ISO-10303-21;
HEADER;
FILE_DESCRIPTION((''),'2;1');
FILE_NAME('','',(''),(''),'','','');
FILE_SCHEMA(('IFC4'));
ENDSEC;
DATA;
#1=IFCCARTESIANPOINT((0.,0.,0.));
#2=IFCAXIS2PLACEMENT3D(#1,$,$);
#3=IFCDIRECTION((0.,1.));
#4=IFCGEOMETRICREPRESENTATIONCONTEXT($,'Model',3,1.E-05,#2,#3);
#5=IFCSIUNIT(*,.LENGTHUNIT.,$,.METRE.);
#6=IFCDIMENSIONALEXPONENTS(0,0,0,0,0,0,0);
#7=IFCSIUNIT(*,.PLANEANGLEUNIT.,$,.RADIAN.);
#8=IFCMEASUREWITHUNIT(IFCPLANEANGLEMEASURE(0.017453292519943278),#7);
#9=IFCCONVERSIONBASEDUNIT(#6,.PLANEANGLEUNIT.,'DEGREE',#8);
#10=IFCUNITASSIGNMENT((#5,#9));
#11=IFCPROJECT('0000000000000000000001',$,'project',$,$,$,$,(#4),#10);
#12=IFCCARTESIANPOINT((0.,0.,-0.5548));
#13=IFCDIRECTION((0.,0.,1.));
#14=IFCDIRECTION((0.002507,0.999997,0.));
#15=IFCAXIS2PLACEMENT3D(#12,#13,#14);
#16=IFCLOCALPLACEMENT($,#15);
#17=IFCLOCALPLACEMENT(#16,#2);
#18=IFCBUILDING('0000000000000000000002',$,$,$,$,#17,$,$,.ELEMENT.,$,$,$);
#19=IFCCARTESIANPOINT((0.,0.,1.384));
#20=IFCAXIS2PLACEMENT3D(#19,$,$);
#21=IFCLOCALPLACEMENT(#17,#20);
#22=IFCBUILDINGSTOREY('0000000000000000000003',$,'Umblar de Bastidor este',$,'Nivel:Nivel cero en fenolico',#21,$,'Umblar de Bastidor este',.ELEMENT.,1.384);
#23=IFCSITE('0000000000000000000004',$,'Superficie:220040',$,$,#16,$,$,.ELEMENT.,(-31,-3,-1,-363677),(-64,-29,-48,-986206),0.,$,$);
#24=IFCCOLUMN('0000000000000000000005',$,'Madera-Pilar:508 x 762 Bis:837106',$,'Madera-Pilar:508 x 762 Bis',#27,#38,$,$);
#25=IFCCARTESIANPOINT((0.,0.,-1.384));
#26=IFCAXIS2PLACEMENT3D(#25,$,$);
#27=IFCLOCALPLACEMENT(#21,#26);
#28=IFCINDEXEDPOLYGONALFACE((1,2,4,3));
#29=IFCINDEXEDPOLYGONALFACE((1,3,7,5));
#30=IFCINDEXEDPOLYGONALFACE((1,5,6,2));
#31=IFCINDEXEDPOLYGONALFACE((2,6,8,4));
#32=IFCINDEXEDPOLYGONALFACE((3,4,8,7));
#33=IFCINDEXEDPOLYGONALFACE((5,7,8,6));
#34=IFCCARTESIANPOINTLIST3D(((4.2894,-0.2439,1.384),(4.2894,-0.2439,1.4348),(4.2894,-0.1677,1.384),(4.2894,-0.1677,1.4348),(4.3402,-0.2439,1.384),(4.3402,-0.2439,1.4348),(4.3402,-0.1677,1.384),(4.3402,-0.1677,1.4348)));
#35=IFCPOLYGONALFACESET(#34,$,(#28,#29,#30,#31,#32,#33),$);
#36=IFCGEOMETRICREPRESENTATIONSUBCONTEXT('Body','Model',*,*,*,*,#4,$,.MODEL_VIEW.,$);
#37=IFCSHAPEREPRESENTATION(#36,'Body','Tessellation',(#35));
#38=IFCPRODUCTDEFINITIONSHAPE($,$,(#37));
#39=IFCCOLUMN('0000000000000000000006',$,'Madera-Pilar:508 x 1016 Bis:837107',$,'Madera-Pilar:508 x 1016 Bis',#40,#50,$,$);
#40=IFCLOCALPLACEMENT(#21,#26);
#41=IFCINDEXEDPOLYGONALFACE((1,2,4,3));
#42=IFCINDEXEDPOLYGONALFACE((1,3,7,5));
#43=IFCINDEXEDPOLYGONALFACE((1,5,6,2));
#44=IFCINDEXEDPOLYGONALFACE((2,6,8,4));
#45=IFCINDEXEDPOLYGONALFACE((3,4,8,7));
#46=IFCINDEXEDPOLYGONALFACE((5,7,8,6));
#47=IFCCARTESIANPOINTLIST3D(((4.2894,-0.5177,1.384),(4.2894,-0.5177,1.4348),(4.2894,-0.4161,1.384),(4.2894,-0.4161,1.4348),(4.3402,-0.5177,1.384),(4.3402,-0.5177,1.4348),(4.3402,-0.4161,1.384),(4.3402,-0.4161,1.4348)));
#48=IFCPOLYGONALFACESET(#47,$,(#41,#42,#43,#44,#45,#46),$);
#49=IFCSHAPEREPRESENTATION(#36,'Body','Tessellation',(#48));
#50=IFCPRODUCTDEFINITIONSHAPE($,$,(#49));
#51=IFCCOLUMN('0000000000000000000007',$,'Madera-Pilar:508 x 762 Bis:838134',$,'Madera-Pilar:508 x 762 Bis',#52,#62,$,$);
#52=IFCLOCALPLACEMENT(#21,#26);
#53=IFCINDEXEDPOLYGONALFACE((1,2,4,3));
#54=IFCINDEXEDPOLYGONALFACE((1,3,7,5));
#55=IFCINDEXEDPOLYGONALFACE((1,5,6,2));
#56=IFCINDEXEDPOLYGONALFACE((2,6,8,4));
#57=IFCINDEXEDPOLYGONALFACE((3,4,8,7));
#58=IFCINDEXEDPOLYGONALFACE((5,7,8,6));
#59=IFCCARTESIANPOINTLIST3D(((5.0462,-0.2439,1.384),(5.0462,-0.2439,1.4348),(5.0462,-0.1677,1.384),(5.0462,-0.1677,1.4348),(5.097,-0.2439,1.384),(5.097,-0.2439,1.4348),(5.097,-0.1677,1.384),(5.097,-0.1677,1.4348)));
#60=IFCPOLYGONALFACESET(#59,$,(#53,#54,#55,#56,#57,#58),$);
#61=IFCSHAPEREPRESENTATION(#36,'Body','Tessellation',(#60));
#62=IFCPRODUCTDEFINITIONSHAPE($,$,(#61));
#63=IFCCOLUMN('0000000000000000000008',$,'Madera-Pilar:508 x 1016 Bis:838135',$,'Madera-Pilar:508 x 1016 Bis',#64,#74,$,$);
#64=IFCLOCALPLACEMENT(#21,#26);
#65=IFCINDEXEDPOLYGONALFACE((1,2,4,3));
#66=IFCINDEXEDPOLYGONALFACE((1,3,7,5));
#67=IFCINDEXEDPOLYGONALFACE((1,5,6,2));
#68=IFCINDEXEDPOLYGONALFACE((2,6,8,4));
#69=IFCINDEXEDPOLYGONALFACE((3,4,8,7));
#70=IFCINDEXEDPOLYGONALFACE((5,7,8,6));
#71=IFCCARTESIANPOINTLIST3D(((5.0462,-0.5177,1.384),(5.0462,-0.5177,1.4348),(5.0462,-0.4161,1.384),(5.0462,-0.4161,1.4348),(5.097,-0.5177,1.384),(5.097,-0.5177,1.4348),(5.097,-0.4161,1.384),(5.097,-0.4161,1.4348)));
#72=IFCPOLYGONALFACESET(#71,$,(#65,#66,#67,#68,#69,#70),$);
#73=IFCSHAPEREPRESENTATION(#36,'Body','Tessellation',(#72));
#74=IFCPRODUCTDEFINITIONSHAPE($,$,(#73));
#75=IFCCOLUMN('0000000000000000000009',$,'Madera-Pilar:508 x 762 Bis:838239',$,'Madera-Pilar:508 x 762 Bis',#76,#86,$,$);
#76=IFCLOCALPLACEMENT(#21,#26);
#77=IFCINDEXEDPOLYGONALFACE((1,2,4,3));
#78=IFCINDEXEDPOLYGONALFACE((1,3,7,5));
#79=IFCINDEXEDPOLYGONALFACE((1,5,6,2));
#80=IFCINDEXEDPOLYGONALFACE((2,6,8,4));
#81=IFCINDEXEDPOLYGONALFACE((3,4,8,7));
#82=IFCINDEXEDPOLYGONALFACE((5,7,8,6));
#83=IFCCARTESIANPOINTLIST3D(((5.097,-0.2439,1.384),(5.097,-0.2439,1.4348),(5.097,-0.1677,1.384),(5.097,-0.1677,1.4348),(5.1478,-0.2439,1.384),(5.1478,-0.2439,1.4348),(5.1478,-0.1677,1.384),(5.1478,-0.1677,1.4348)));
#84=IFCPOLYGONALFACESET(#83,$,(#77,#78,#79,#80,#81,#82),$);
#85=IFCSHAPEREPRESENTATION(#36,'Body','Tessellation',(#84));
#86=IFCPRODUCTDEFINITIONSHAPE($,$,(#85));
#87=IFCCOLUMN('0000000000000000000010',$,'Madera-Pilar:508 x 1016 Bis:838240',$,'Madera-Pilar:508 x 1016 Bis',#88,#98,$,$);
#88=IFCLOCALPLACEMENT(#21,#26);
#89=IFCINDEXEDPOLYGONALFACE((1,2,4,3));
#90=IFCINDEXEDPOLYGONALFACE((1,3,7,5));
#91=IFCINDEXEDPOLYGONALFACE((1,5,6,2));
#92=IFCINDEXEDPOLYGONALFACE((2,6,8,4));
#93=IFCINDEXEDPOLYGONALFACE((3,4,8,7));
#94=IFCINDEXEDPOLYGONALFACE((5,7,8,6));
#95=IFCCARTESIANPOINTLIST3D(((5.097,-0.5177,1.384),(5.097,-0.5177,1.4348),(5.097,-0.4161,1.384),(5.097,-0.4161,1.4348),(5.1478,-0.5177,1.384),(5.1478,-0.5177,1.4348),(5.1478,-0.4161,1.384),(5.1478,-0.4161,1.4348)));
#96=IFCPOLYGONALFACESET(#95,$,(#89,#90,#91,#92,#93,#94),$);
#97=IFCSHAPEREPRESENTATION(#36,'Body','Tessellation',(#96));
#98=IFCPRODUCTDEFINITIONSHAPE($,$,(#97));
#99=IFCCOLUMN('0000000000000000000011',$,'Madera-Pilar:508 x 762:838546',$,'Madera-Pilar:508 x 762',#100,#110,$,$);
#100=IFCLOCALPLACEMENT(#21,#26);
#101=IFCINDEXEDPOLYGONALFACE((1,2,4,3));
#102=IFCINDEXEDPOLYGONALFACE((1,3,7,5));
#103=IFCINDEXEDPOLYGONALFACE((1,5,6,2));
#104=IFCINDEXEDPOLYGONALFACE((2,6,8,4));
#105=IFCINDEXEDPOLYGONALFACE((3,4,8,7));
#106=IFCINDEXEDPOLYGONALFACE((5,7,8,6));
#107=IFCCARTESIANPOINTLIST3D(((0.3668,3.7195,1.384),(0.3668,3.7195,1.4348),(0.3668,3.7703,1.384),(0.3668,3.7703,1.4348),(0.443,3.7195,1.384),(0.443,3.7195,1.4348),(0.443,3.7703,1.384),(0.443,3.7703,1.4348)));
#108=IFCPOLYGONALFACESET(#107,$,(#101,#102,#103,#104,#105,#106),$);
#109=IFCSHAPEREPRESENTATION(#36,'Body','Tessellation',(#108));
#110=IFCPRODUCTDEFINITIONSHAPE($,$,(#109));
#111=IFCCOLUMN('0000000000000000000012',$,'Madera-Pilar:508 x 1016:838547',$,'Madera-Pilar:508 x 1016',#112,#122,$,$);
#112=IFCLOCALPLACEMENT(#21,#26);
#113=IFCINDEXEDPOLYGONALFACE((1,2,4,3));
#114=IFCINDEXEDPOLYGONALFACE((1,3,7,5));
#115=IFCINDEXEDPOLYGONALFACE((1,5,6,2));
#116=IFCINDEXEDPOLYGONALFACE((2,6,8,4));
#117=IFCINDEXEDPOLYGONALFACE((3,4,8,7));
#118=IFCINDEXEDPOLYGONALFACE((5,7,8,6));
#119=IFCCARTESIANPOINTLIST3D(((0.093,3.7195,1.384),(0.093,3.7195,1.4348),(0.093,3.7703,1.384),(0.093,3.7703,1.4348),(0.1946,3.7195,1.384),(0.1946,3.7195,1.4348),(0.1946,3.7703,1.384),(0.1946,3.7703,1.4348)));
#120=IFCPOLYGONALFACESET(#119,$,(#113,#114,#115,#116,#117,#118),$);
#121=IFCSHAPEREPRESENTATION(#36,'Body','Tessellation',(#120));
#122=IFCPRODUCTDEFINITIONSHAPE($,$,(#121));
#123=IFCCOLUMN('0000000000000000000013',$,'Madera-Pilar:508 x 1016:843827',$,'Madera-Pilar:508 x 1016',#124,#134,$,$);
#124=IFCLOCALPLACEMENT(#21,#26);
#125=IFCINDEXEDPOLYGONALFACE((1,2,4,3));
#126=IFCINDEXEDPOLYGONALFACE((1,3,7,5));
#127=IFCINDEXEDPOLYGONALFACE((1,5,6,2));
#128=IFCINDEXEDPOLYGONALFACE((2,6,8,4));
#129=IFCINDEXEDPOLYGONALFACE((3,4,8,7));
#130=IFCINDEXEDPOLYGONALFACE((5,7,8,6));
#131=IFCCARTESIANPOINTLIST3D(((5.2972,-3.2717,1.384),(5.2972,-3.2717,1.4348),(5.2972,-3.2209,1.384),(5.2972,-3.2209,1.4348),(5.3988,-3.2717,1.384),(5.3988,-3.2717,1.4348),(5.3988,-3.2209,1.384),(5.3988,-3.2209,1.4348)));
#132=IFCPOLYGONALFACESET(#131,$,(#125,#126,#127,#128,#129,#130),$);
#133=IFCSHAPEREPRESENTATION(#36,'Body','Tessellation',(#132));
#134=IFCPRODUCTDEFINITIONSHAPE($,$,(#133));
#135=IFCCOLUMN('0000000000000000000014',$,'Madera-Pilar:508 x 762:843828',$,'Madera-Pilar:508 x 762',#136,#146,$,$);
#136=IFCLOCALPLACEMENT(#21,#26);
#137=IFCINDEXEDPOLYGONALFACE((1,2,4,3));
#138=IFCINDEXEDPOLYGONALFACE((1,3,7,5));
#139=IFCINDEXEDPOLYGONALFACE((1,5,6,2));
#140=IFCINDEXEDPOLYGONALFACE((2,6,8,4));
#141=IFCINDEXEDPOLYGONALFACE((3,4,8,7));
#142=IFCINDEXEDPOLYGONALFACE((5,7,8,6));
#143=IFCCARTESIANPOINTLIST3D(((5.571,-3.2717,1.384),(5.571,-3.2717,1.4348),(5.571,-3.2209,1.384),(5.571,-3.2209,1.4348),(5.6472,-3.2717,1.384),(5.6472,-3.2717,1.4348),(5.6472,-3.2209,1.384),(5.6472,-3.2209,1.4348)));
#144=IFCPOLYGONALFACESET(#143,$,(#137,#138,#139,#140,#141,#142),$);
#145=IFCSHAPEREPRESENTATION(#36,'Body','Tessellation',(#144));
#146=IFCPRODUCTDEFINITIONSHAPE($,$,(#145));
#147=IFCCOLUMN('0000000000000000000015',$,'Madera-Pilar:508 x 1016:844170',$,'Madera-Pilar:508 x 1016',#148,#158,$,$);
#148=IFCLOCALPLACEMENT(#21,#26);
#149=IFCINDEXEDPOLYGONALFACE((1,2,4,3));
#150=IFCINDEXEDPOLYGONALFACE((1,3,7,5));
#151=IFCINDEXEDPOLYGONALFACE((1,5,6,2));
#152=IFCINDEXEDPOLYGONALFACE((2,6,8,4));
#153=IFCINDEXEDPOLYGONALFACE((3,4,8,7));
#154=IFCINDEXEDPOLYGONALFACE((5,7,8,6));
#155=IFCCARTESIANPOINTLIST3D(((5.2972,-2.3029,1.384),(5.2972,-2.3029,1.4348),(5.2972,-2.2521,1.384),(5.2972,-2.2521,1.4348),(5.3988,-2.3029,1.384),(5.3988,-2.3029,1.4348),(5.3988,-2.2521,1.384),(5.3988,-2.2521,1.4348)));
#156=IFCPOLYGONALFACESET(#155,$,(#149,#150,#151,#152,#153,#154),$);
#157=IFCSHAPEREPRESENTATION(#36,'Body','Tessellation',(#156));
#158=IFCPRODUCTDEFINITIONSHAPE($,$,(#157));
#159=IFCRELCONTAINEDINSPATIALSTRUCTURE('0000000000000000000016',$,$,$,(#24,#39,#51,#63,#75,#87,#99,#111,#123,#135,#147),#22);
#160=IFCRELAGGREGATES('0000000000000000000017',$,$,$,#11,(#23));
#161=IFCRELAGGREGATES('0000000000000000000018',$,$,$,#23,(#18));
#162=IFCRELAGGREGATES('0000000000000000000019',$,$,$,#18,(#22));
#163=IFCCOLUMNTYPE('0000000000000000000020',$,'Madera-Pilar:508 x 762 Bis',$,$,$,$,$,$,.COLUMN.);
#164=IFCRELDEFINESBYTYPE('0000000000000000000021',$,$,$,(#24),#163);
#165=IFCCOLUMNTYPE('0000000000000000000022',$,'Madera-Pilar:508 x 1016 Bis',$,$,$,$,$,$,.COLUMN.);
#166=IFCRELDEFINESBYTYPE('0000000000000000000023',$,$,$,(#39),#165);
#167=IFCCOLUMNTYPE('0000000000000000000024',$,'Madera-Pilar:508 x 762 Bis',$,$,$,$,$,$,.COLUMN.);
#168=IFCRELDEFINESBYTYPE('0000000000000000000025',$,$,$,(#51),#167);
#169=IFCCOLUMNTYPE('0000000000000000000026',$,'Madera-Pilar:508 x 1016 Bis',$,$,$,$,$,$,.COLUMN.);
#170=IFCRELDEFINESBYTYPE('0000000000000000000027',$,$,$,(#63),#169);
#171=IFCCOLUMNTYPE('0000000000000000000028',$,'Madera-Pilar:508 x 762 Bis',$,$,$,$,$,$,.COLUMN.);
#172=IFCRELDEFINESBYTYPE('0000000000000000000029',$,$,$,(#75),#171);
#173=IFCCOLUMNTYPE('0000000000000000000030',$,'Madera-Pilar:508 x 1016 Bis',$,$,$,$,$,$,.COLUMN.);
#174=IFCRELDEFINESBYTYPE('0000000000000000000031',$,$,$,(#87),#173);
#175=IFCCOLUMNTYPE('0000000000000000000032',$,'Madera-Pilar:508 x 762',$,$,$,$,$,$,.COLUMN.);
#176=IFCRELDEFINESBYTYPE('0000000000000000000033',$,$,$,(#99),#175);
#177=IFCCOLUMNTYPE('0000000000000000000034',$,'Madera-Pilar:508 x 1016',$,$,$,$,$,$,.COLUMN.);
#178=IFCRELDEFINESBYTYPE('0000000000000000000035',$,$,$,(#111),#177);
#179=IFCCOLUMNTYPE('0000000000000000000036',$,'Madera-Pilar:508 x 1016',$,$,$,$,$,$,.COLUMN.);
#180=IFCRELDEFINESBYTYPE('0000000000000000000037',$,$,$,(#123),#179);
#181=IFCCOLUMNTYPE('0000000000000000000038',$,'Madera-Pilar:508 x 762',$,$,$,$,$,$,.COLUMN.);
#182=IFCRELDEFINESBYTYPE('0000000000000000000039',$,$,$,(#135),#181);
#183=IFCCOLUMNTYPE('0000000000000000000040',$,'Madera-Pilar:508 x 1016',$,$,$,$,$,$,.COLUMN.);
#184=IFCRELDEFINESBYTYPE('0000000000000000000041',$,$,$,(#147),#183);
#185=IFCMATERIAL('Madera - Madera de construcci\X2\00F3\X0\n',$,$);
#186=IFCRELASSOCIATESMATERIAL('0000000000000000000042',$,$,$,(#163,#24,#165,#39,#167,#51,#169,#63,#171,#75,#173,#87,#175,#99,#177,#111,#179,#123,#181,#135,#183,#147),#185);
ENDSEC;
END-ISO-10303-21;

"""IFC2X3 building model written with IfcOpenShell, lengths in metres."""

from ifc_helpers import new_model, entity, si_unit, converted_unit, direction, frame, frame_2d, origin, origin_2d_with_axis, place, context, subcontext, project, spatial, rectangle, extrude, source, transform, mapped, material, type_object, type_shapes, element, save


model = new_model("IFC2X3")

# Units and contexts
model_context = context("Model", 3, precision=1e-05, world=origin(), true_north=direction((0.0, 1.0)))
body_context = subcontext(model_context, "Body", "Model", "MODEL_VIEW")
ifc_project = project(units=[si_unit("LENGTHUNIT", "METRE"), converted_unit("PLANEANGLEUNIT", "DEGREE", entity("IfcPlaneAngleMeasure", 0.017453292519943278), si_unit("PLANEANGLEUNIT", "RADIAN"), dimensions=[0, 0, 0, 0, 0, 0, 0])], contexts=[model_context])

# Site, building, storey
site_placement = place(None, frame((0.0, 0.0, -0.5548), z_axis=(0.0, 0.0, 1.0), x_axis=(0.002507, 0.999997, 0.0)))
site = spatial("IfcSite", under=ifc_project, at=site_placement, Name="Superficie:220040", CompositionType="ELEMENT", RefLatitude=(-31, -3, -1, -363677), RefLongitude=(-64, -29, -48, -986206), RefElevation=0.0)
building_placement = place(site_placement, origin())
building = spatial("IfcBuilding", under=site, at=building_placement, CompositionType="ELEMENT")
storey_placement = place(building_placement, frame((0.0, 0.0, 1.384)))
storey = spatial("IfcBuildingStorey", under=building, at=storey_placement, Name="Umblar de Bastidor este", ObjectType="Nivel:Nivel cero en fenolico", LongName="Umblar de Bastidor este", CompositionType="ELEMENT", Elevation=1.384)

# Columns
ifc_material = material(Name="Madera - Madera de construcción")
column_type_1 = type_object("IfcColumnType", Name="Madera-Pilar:508 x 762 Bis", PredefinedType="COLUMN", material=ifc_material)
shared_shape_1 = source(origin(), body_context, "Body", "SweptSolid", [
    extrude(rectangle(XDim=0.0508, YDim=0.0762, at=frame_2d((0.0, 0.0), x_axis=(1.0, 0.0))), frame((4.3148, -0.2058, 1.384), z_axis=(0.0, 0.0, 1.0), x_axis=(-1.0, 0.0, 0.0)), (0.0, 0.0, 1.0), 0.0508),
])
type_shapes(column_type_1, [shared_shape_1])
column_1_placement = place(storey_placement, frame((0.0, 0.0, -1.384)))
element("IfcColumn", 1, at=column_1_placement, inside=storey, type_object=column_type_1, material=ifc_material, Name="Madera-Pilar:508 x 762 Bis:837106", ObjectType="Madera-Pilar:508 x 762 Bis", context=body_context, shape_type="MappedRepresentation", body=[
    mapped(shared_shape_1, transform((0.0, 0.0, 0.0), scale=1.0)),
])
column_type_2 = type_object("IfcColumnType", Name="Madera-Pilar:508 x 1016 Bis", PredefinedType="COLUMN", material=ifc_material)
shared_shape_2 = source(origin(), body_context, "Body", "SweptSolid", [
    extrude(rectangle(XDim=0.0508, YDim=0.1016, at=frame_2d((0.0, 0.0), x_axis=(1.0, 0.0))), frame((4.3148, -0.4669, 1.384)), (0.0, 0.0, 1.0), 0.0508),
])
type_shapes(column_type_2, [shared_shape_2])
column_2_placement = place(storey_placement, frame((0.0, 0.0, -1.384)))
element("IfcColumn", 2, at=column_2_placement, inside=storey, type_object=column_type_2, material=ifc_material, Name="Madera-Pilar:508 x 1016 Bis:837107", ObjectType="Madera-Pilar:508 x 1016 Bis", context=body_context, shape_type="MappedRepresentation", body=[
    mapped(shared_shape_2, transform((0.0, 0.0, 0.0), scale=1.0)),
])
column_type_3 = type_object("IfcColumnType", Name="Madera-Pilar:508 x 762 Bis", PredefinedType="COLUMN", material=ifc_material)
shared_shape_3 = source(origin(), body_context, "Body", "SweptSolid", [
    extrude(rectangle(XDim=0.0508, YDim=0.0762, at=frame_2d((0.0, 0.0), x_axis=(1.0, 0.0))), frame((5.0716, -0.2058, 1.384), z_axis=(0.0, 0.0, 1.0), x_axis=(-1.0, 0.0, 0.0)), (0.0, 0.0, 1.0), 0.0508),
])
type_shapes(column_type_3, [shared_shape_3])
column_3_placement = place(storey_placement, frame((0.0, 0.0, -1.384)))
element("IfcColumn", 3, at=column_3_placement, inside=storey, type_object=column_type_3, material=ifc_material, Name="Madera-Pilar:508 x 762 Bis:838134", ObjectType="Madera-Pilar:508 x 762 Bis", context=body_context, shape_type="MappedRepresentation", body=[
    mapped(shared_shape_3, transform((0.0, 0.0, 0.0), scale=1.0)),
])
column_type_4 = type_object("IfcColumnType", Name="Madera-Pilar:508 x 1016 Bis", PredefinedType="COLUMN", material=ifc_material)
shared_shape_4 = source(origin(), body_context, "Body", "SweptSolid", [
    extrude(rectangle(XDim=0.0508, YDim=0.1016, at=frame_2d((0.0, 0.0), x_axis=(1.0, 0.0))), frame((5.0716, -0.4669, 1.384)), (0.0, 0.0, 1.0), 0.0508),
])
type_shapes(column_type_4, [shared_shape_4])
column_4_placement = place(storey_placement, frame((0.0, 0.0, -1.384)))
element("IfcColumn", 4, at=column_4_placement, inside=storey, type_object=column_type_4, material=ifc_material, Name="Madera-Pilar:508 x 1016 Bis:838135", ObjectType="Madera-Pilar:508 x 1016 Bis", context=body_context, shape_type="MappedRepresentation", body=[
    mapped(shared_shape_4, transform((0.0, 0.0, 0.0), scale=1.0)),
])
column_type_5 = type_object("IfcColumnType", Name="Madera-Pilar:508 x 762 Bis", PredefinedType="COLUMN", material=ifc_material)
shared_shape_5 = source(origin(), body_context, "Body", "SweptSolid", [
    extrude(rectangle(XDim=0.0508, YDim=0.0762, at=frame_2d((0.0, 0.0), x_axis=(1.0, 0.0))), frame((5.1224, -0.2058, 1.384), z_axis=(0.0, 0.0, 1.0), x_axis=(-1.0, 0.0, 0.0)), (0.0, 0.0, 1.0), 0.0508),
])
type_shapes(column_type_5, [shared_shape_5])
column_5_placement = place(storey_placement, frame((0.0, 0.0, -1.384)))
element("IfcColumn", 5, at=column_5_placement, inside=storey, type_object=column_type_5, material=ifc_material, Name="Madera-Pilar:508 x 762 Bis:838239", ObjectType="Madera-Pilar:508 x 762 Bis", context=body_context, shape_type="MappedRepresentation", body=[
    mapped(shared_shape_5, transform((0.0, 0.0, 0.0), scale=1.0)),
])
column_type_6 = type_object("IfcColumnType", Name="Madera-Pilar:508 x 1016 Bis", PredefinedType="COLUMN", material=ifc_material)
shared_shape_6 = source(origin(), body_context, "Body", "SweptSolid", [
    extrude(rectangle(XDim=0.0508, YDim=0.1016, at=frame_2d((0.0, 0.0), x_axis=(1.0, 0.0))), frame((5.1224, -0.4669, 1.384)), (0.0, 0.0, 1.0), 0.0508),
])
type_shapes(column_type_6, [shared_shape_6])
column_6_placement = place(storey_placement, frame((0.0, 0.0, -1.384)))
element("IfcColumn", 6, at=column_6_placement, inside=storey, type_object=column_type_6, material=ifc_material, Name="Madera-Pilar:508 x 1016 Bis:838240", ObjectType="Madera-Pilar:508 x 1016 Bis", context=body_context, shape_type="MappedRepresentation", body=[
    mapped(shared_shape_6, transform((0.0, 0.0, 0.0), scale=1.0)),
])
column_type_7 = type_object("IfcColumnType", Name="Madera-Pilar:508 x 762", PredefinedType="COLUMN", material=ifc_material)
shared_shape_7 = source(origin(), body_context, "Body", "SweptSolid", [
    extrude(rectangle(XDim=0.0762, YDim=0.0508, at=origin_2d_with_axis()), frame((0.4049, 3.7449, 1.384), z_axis=(0.0, 0.0, 1.0), x_axis=(-1.0, 0.0, 0.0)), (0.0, 0.0, 1.0), 0.0508),
])
type_shapes(column_type_7, [shared_shape_7])
column_7_placement = place(storey_placement, frame((0.0, 0.0, -1.384)))
element("IfcColumn", 7, at=column_7_placement, inside=storey, type_object=column_type_7, material=ifc_material, Name="Madera-Pilar:508 x 762:838546", ObjectType="Madera-Pilar:508 x 762", context=body_context, shape_type="MappedRepresentation", body=[
    mapped(shared_shape_7, transform((0.0, 0.0, 0.0), scale=1.0)),
])
column_type_8 = type_object("IfcColumnType", Name="Madera-Pilar:508 x 1016", PredefinedType="COLUMN", material=ifc_material)
shared_shape_8 = source(origin(), body_context, "Body", "SweptSolid", [
    extrude(rectangle(XDim=0.1016, YDim=0.0508, at=frame_2d((0.0, 0.0), x_axis=(1.0, 0.0))), frame((0.1438, 3.7449, 1.384), z_axis=(0.0, 0.0, 1.0), x_axis=(-1.0, 0.0, 0.0)), (0.0, 0.0, 1.0), 0.0508),
])
type_shapes(column_type_8, [shared_shape_8])
column_8_placement = place(storey_placement, frame((0.0, 0.0, -1.384)))
element("IfcColumn", 8, at=column_8_placement, inside=storey, type_object=column_type_8, material=ifc_material, Name="Madera-Pilar:508 x 1016:838547", ObjectType="Madera-Pilar:508 x 1016", context=body_context, shape_type="MappedRepresentation", body=[
    mapped(shared_shape_8, transform((0.0, 0.0, 0.0), scale=1.0)),
])
column_type_9 = type_object("IfcColumnType", Name="Madera-Pilar:508 x 1016", PredefinedType="COLUMN", material=ifc_material)
shared_shape_9 = source(origin(), body_context, "Body", "SweptSolid", [
    extrude(rectangle(XDim=0.1016, YDim=0.0508, at=origin_2d_with_axis()), frame((5.348, -3.2463, 1.384), z_axis=(0.0, 0.0, 1.0), x_axis=(-1.0, 0.0, 0.0)), (0.0, 0.0, 1.0), 0.0508),
])
type_shapes(column_type_9, [shared_shape_9])
column_9_placement = place(storey_placement, frame((0.0, 0.0, -1.384)))
element("IfcColumn", 9, at=column_9_placement, inside=storey, type_object=column_type_9, material=ifc_material, Name="Madera-Pilar:508 x 1016:843827", ObjectType="Madera-Pilar:508 x 1016", context=body_context, shape_type="MappedRepresentation", body=[
    mapped(shared_shape_9, transform((0.0, 0.0, 0.0), scale=1.0)),
])
column_type_10 = type_object("IfcColumnType", Name="Madera-Pilar:508 x 762", PredefinedType="COLUMN", material=ifc_material)
shared_shape_10 = source(origin(), body_context, "Body", "SweptSolid", [
    extrude(rectangle(XDim=0.0762, YDim=0.0508, at=origin_2d_with_axis()), frame((5.6091, -3.2463, 1.384), z_axis=(0.0, 0.0, 1.0), x_axis=(-1.0, 0.0, 0.0)), (0.0, 0.0, 1.0), 0.0508),
])
type_shapes(column_type_10, [shared_shape_10])
column_10_placement = place(storey_placement, frame((0.0, 0.0, -1.384)))
element("IfcColumn", 10, at=column_10_placement, inside=storey, type_object=column_type_10, material=ifc_material, Name="Madera-Pilar:508 x 762:843828", ObjectType="Madera-Pilar:508 x 762", context=body_context, shape_type="MappedRepresentation", body=[
    mapped(shared_shape_10, transform((0.0, 0.0, 0.0), scale=1.0)),
])
column_type_11 = type_object("IfcColumnType", Name="Madera-Pilar:508 x 1016", PredefinedType="COLUMN", material=ifc_material)
shared_shape_11 = source(origin(), body_context, "Body", "SweptSolid", [
    extrude(rectangle(XDim=0.1016, YDim=0.0508, at=origin_2d_with_axis()), frame((5.348, -2.2775, 1.384), z_axis=(0.0, 0.0, 1.0), x_axis=(-1.0, 0.0, 0.0)), (0.0, 0.0, 1.0), 0.0508),
])
type_shapes(column_type_11, [shared_shape_11])
column_11_placement = place(storey_placement, frame((0.0, 0.0, -1.384)))
element("IfcColumn", 11, at=column_11_placement, inside=storey, type_object=column_type_11, material=ifc_material, Name="Madera-Pilar:508 x 1016:844170", ObjectType="Madera-Pilar:508 x 1016", context=body_context, shape_type="MappedRepresentation", body=[
    mapped(shared_shape_11, transform((0.0, 0.0, 0.0), scale=1.0)),
])

save(model, "model.ifc")
